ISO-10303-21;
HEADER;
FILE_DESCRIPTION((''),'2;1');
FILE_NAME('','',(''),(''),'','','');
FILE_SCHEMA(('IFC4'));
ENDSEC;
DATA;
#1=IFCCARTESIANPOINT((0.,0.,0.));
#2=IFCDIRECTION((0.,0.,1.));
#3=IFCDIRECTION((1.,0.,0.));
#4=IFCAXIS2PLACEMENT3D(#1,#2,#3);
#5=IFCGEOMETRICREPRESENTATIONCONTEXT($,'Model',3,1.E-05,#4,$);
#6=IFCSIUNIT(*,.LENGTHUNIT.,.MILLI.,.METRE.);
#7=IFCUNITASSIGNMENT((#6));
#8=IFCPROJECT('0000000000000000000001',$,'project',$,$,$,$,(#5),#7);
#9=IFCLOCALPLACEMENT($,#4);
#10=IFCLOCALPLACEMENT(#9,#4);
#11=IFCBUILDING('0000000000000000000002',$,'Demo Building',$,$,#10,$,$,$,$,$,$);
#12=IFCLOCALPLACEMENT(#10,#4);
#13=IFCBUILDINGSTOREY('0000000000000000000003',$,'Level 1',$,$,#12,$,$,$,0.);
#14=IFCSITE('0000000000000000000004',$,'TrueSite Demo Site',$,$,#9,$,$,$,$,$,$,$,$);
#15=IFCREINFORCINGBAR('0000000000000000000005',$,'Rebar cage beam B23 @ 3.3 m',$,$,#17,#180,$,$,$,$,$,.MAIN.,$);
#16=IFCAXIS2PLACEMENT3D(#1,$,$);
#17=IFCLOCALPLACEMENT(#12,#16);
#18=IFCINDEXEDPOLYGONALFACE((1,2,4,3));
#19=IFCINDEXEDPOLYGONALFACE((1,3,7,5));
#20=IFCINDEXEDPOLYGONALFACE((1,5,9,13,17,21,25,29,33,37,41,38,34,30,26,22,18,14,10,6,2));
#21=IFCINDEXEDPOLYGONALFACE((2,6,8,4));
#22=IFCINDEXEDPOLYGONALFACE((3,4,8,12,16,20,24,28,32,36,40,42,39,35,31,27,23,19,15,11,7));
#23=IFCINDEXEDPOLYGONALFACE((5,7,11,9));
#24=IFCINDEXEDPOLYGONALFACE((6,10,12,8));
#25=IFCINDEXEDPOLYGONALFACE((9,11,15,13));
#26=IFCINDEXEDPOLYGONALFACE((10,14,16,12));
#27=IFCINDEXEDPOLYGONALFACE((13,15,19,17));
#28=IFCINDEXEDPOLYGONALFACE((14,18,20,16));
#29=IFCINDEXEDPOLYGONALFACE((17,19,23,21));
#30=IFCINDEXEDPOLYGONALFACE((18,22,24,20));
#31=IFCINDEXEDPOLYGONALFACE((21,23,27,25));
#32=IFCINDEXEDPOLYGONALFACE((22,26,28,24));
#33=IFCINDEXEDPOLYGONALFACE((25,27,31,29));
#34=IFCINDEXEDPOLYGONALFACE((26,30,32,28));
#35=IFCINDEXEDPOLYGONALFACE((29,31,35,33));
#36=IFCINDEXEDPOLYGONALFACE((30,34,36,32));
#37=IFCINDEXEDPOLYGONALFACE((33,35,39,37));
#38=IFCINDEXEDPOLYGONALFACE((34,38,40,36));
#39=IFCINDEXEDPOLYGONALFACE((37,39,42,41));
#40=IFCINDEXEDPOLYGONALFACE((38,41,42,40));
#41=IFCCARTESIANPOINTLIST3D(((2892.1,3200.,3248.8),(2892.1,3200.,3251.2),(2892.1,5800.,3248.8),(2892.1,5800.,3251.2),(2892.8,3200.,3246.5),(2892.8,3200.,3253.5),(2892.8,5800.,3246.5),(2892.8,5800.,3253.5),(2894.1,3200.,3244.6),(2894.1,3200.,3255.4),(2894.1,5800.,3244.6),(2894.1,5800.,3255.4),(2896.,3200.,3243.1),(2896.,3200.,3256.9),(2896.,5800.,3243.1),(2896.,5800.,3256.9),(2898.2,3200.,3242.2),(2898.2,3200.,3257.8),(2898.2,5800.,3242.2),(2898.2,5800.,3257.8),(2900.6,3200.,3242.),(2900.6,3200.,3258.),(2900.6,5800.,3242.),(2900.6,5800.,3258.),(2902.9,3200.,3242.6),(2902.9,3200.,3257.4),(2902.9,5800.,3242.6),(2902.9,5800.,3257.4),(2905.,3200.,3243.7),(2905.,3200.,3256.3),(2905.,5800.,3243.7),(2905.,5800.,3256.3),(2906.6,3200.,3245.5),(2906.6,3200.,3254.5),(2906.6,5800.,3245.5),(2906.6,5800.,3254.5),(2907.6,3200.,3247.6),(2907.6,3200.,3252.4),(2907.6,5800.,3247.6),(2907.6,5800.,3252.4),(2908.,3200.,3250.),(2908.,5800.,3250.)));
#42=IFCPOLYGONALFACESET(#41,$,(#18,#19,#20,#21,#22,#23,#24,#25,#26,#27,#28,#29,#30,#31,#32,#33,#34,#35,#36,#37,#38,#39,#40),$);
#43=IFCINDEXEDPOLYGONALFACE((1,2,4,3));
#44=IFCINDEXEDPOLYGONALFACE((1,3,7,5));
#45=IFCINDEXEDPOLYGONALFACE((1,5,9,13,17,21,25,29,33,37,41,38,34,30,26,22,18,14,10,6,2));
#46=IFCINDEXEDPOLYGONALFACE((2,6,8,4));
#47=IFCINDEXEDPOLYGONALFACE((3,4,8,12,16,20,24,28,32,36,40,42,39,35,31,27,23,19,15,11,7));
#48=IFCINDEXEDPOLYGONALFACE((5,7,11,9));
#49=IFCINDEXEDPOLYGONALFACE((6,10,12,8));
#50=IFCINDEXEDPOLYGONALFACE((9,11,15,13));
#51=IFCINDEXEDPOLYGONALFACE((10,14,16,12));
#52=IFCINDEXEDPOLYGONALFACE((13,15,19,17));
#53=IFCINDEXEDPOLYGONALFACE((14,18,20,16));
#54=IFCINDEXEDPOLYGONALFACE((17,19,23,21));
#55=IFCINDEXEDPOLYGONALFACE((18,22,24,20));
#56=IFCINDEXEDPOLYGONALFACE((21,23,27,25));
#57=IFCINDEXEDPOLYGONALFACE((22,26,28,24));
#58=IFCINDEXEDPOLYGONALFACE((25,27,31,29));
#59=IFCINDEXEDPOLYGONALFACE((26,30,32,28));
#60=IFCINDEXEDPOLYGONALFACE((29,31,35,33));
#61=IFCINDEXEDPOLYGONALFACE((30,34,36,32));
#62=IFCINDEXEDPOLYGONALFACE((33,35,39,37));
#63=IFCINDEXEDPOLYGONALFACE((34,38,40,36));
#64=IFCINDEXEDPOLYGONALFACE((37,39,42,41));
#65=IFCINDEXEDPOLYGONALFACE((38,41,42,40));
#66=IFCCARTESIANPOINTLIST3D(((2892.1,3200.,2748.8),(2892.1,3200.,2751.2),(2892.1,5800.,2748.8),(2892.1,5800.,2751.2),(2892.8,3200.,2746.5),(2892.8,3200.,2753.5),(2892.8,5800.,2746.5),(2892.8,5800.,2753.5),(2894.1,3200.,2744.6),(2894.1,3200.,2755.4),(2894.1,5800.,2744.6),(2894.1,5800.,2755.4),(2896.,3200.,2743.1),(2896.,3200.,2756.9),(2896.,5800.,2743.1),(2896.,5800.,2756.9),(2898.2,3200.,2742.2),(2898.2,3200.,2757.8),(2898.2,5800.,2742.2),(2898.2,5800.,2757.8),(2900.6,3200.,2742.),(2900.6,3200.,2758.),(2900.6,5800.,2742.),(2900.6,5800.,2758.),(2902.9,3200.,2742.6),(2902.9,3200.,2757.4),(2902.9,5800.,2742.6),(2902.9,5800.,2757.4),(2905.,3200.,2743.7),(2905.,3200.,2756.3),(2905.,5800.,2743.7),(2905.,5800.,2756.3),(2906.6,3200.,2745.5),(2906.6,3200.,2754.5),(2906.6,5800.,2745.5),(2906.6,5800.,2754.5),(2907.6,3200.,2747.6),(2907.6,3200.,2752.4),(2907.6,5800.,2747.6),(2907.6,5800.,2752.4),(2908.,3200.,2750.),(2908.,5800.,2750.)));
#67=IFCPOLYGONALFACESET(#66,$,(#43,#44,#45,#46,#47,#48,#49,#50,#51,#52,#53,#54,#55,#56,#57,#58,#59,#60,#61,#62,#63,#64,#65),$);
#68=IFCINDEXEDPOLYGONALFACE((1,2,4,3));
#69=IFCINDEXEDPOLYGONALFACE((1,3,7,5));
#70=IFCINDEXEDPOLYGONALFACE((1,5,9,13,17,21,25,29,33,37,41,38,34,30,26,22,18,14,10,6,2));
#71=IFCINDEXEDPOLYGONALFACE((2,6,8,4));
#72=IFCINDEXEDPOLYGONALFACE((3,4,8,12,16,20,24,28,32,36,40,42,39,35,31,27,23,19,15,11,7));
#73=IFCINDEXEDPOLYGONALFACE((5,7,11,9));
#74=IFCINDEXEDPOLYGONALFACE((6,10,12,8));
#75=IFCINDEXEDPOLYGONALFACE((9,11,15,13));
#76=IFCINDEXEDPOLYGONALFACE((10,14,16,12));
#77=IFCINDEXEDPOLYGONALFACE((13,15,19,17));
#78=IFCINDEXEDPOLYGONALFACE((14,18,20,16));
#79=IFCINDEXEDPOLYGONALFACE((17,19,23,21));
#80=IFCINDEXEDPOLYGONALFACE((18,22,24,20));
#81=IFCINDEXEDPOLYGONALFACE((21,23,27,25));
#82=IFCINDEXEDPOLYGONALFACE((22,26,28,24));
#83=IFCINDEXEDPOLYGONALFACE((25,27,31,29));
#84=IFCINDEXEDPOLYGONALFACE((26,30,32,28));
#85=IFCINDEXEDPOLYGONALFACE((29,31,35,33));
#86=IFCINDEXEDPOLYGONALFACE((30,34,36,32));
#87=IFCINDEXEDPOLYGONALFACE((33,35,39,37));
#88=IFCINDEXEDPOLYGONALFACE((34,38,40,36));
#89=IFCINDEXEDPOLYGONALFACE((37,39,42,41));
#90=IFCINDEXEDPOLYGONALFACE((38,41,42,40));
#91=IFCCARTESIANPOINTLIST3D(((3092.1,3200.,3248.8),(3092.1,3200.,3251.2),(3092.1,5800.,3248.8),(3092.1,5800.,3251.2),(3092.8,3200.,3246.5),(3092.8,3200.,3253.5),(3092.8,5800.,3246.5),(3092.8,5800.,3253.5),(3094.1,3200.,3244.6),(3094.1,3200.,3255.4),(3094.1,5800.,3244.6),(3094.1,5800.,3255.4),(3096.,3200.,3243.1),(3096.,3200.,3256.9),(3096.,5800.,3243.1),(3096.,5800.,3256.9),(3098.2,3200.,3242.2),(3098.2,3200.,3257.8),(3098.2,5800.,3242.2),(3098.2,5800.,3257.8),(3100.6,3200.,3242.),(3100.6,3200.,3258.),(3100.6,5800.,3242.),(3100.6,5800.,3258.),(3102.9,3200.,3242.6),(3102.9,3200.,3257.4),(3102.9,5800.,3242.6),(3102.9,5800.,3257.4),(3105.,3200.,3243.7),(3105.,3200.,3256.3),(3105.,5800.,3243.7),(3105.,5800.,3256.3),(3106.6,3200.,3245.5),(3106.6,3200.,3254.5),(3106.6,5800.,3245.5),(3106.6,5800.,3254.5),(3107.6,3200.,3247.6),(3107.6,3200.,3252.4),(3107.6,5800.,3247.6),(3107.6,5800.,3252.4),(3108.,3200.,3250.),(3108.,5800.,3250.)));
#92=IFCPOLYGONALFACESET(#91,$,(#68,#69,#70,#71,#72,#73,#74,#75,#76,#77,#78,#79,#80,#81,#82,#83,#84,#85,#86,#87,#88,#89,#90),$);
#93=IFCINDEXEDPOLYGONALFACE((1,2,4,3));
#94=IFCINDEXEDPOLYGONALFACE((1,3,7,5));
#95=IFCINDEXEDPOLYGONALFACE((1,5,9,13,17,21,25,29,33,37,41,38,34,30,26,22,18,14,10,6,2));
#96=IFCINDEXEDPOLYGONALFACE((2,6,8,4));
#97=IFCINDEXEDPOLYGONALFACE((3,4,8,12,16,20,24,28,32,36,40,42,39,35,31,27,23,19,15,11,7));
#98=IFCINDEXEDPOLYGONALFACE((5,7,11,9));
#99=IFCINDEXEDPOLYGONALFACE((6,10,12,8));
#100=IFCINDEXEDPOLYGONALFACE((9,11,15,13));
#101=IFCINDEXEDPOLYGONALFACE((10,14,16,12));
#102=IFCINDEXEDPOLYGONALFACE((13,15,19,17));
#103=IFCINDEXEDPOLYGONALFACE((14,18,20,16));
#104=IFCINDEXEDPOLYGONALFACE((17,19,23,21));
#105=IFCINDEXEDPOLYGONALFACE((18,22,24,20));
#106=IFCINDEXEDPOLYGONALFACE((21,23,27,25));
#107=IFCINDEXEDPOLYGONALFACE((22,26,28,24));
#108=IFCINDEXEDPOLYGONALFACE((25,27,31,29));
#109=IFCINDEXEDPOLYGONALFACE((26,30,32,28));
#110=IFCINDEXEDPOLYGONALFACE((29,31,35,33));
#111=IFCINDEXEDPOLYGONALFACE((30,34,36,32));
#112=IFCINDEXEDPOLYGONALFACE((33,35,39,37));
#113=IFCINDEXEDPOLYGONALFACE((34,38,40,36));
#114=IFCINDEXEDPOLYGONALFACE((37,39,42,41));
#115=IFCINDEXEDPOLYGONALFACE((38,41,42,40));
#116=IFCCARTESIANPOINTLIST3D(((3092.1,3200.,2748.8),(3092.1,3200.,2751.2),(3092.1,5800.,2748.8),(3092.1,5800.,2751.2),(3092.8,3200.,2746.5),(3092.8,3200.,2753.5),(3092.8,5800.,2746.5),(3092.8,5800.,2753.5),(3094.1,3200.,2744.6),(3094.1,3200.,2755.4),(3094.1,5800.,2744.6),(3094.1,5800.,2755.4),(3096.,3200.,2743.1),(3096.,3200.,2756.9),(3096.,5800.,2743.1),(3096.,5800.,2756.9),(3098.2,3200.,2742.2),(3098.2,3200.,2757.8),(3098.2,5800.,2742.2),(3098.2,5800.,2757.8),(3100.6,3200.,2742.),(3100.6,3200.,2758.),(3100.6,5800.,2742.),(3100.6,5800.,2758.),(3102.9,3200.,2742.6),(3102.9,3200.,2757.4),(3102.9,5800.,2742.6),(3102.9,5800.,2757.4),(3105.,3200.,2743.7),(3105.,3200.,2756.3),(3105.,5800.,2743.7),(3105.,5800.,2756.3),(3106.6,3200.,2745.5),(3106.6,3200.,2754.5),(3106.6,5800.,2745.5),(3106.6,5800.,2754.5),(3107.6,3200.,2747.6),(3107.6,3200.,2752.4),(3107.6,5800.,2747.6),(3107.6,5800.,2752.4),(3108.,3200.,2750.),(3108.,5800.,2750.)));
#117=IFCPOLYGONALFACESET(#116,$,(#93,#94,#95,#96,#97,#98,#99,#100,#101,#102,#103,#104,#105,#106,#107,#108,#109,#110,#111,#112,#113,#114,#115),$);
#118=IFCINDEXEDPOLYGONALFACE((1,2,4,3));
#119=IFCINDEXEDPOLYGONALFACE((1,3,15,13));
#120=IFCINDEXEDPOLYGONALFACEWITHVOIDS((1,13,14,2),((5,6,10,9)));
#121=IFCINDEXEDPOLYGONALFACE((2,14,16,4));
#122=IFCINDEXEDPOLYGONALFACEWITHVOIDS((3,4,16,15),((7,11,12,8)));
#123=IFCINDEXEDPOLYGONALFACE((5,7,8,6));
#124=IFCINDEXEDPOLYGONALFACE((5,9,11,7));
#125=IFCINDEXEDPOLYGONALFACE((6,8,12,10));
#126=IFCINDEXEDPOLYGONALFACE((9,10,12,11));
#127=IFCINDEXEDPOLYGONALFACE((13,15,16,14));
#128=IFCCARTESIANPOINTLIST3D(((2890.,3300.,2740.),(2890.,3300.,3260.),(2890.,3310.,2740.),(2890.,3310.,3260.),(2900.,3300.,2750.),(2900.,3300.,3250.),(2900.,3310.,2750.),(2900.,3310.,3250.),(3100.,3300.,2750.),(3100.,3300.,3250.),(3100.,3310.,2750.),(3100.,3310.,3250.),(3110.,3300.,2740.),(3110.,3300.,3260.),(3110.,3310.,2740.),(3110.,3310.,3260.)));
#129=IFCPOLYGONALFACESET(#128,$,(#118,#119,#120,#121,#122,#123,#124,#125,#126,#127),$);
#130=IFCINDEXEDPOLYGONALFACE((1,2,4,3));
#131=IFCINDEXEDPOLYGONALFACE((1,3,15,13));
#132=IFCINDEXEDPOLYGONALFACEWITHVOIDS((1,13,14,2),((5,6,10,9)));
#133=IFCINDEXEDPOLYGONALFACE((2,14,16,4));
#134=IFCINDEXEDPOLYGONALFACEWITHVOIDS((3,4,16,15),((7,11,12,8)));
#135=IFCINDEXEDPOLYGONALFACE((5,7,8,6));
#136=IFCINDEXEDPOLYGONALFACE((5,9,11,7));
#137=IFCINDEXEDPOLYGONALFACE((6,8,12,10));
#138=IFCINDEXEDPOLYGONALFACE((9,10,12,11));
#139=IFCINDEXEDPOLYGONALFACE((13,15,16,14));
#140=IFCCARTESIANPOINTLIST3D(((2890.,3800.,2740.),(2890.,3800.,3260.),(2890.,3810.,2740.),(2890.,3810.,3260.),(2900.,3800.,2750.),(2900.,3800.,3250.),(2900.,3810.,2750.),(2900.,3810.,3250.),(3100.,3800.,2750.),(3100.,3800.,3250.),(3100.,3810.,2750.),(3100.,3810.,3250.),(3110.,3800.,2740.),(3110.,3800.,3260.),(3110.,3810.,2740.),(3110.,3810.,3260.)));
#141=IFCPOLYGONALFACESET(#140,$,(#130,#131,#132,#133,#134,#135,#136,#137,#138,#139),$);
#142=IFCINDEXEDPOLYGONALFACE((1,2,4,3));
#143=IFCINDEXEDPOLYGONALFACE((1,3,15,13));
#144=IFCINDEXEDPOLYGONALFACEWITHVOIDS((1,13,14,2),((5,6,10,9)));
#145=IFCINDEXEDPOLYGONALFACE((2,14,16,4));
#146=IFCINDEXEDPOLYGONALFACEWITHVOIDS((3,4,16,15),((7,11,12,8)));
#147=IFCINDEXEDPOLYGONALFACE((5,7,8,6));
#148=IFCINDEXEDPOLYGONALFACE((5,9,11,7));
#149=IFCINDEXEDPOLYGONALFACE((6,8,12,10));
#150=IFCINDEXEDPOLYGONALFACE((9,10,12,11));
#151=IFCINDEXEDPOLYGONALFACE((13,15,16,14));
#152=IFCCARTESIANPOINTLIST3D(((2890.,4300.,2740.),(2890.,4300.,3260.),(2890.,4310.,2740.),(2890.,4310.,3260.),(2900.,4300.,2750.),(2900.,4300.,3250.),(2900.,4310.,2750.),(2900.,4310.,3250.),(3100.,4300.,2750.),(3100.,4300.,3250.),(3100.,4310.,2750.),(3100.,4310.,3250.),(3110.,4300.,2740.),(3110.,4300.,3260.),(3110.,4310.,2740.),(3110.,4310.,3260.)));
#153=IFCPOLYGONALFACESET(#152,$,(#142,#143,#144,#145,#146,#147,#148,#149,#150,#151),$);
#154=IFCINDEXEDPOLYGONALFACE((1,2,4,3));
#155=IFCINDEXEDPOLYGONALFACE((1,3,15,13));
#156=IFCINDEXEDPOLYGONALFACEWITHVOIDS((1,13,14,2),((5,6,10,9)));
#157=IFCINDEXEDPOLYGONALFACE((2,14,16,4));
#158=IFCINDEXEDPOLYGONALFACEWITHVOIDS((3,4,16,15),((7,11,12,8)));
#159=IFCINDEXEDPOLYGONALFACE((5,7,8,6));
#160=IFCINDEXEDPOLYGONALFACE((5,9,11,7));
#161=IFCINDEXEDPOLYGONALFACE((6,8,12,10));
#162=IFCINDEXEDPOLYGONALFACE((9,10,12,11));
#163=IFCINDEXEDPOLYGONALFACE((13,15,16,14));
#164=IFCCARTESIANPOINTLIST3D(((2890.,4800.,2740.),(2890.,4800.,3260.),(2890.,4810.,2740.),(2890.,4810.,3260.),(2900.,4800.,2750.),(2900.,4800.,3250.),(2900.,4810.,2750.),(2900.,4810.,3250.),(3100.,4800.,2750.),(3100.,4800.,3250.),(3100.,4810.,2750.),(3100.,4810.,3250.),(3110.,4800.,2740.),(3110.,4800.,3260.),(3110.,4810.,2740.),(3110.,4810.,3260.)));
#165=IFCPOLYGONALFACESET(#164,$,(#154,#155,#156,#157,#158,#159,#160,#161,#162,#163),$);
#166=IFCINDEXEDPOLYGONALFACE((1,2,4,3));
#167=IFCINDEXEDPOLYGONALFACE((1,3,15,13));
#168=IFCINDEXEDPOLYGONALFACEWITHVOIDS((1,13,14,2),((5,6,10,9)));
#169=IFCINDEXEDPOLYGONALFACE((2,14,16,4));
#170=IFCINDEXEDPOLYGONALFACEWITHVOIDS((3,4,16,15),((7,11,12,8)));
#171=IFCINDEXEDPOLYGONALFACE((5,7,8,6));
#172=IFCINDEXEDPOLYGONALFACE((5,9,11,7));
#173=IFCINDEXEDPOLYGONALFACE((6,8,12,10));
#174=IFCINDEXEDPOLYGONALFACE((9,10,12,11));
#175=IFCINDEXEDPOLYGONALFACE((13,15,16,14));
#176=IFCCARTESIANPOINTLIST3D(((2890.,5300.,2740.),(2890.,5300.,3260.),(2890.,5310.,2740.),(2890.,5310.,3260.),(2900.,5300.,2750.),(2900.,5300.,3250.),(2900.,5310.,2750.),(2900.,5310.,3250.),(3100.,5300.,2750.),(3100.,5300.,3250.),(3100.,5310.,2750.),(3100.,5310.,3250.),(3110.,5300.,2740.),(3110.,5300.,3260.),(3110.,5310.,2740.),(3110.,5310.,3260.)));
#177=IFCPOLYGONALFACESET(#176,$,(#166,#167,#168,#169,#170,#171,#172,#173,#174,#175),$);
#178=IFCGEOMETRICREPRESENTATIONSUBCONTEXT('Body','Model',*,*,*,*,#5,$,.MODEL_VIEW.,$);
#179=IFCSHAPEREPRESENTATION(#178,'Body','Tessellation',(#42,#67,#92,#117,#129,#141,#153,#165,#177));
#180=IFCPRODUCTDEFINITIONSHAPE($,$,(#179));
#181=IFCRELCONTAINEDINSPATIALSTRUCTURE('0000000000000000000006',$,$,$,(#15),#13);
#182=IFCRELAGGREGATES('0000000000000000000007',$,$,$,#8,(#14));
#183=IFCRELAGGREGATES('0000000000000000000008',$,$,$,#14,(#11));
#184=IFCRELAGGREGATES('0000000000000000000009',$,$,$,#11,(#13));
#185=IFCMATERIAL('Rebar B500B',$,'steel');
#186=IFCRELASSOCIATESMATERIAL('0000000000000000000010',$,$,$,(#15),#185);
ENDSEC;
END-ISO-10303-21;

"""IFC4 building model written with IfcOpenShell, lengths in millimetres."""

from ifc_helpers import new_model, si_unit, frame, origin_with_axes, place, context, subcontext, project, spatial, hollow_rectangle, circle, extrude, material, element, save


model = new_model("IFC4")

# Units and contexts
model_context = context("Model", 3, precision=1e-05, world=origin_with_axes())
body_context = subcontext(model_context, "Body", "Model", "MODEL_VIEW")
ifc_project = project(units=[si_unit("LENGTHUNIT", "METRE", prefix="MILLI")], contexts=[model_context])

# Site, building, storey
site_placement = place(None, origin_with_axes())
site = spatial("IfcSite", under=ifc_project, at=site_placement, Name="TrueSite Demo Site")
building_placement = place(site_placement, origin_with_axes())
building = spatial("IfcBuilding", under=site, at=building_placement, Name="Demo Building")
storey_placement = place(building_placement, origin_with_axes())
storey = spatial("IfcBuildingStorey", under=building, at=storey_placement, Name="Level 1", Elevation=0.0)

# Reinforcing bar
ifc_material_1 = material(Name="Rebar B500B", Category="steel")
for number, where, z_axis, x_axis, name in (
    (1, (3000.0, 3200.0, 3000.0), (0.0, 1.0, 0.0), (1.0, 0.0, 0.0), "Rebar cage beam B23 @ 3.3 m"),
):
    element("IfcReinforcingBar", number, at=place(storey_placement, frame(where, z_axis=z_axis, x_axis=x_axis)), inside=storey, material=ifc_material_1, Name=name, PredefinedType="MAIN", context=body_context, shape_type="SweptSolid", body=[
        extrude(circle(Radius=8.0), frame((-100.0, -250.0, 0.0)), (0.0, 0.0, 1.0), 2600.0),
        extrude(circle(Radius=8.0), frame((-100.0, 250.0, 0.0)), (0.0, 0.0, 1.0), 2600.0),
        extrude(circle(Radius=8.0), frame((100.0, -250.0, 0.0)), (0.0, 0.0, 1.0), 2600.0),
        extrude(circle(Radius=8.0), frame((100.0, 250.0, 0.0)), (0.0, 0.0, 1.0), 2600.0),
        extrude(hollow_rectangle(XDim=220.0, YDim=520.0, WallThickness=10.0), frame((0.0, 0.0, 100.0)), (0.0, 0.0, 1.0), 10.0),
        extrude(hollow_rectangle(XDim=220.0, YDim=520.0, WallThickness=10.0), frame((0.0, 0.0, 600.0)), (0.0, 0.0, 1.0), 10.0),
        extrude(hollow_rectangle(XDim=220.0, YDim=520.0, WallThickness=10.0), frame((0.0, 0.0, 1100.0)), (0.0, 0.0, 1.0), 10.0),
        extrude(hollow_rectangle(XDim=220.0, YDim=520.0, WallThickness=10.0), frame((0.0, 0.0, 1600.0)), (0.0, 0.0, 1.0), 10.0),
        extrude(hollow_rectangle(XDim=220.0, YDim=520.0, WallThickness=10.0), frame((0.0, 0.0, 2100.0)), (0.0, 0.0, 1.0), 10.0),
    ])

save(model, "model.ifc")
